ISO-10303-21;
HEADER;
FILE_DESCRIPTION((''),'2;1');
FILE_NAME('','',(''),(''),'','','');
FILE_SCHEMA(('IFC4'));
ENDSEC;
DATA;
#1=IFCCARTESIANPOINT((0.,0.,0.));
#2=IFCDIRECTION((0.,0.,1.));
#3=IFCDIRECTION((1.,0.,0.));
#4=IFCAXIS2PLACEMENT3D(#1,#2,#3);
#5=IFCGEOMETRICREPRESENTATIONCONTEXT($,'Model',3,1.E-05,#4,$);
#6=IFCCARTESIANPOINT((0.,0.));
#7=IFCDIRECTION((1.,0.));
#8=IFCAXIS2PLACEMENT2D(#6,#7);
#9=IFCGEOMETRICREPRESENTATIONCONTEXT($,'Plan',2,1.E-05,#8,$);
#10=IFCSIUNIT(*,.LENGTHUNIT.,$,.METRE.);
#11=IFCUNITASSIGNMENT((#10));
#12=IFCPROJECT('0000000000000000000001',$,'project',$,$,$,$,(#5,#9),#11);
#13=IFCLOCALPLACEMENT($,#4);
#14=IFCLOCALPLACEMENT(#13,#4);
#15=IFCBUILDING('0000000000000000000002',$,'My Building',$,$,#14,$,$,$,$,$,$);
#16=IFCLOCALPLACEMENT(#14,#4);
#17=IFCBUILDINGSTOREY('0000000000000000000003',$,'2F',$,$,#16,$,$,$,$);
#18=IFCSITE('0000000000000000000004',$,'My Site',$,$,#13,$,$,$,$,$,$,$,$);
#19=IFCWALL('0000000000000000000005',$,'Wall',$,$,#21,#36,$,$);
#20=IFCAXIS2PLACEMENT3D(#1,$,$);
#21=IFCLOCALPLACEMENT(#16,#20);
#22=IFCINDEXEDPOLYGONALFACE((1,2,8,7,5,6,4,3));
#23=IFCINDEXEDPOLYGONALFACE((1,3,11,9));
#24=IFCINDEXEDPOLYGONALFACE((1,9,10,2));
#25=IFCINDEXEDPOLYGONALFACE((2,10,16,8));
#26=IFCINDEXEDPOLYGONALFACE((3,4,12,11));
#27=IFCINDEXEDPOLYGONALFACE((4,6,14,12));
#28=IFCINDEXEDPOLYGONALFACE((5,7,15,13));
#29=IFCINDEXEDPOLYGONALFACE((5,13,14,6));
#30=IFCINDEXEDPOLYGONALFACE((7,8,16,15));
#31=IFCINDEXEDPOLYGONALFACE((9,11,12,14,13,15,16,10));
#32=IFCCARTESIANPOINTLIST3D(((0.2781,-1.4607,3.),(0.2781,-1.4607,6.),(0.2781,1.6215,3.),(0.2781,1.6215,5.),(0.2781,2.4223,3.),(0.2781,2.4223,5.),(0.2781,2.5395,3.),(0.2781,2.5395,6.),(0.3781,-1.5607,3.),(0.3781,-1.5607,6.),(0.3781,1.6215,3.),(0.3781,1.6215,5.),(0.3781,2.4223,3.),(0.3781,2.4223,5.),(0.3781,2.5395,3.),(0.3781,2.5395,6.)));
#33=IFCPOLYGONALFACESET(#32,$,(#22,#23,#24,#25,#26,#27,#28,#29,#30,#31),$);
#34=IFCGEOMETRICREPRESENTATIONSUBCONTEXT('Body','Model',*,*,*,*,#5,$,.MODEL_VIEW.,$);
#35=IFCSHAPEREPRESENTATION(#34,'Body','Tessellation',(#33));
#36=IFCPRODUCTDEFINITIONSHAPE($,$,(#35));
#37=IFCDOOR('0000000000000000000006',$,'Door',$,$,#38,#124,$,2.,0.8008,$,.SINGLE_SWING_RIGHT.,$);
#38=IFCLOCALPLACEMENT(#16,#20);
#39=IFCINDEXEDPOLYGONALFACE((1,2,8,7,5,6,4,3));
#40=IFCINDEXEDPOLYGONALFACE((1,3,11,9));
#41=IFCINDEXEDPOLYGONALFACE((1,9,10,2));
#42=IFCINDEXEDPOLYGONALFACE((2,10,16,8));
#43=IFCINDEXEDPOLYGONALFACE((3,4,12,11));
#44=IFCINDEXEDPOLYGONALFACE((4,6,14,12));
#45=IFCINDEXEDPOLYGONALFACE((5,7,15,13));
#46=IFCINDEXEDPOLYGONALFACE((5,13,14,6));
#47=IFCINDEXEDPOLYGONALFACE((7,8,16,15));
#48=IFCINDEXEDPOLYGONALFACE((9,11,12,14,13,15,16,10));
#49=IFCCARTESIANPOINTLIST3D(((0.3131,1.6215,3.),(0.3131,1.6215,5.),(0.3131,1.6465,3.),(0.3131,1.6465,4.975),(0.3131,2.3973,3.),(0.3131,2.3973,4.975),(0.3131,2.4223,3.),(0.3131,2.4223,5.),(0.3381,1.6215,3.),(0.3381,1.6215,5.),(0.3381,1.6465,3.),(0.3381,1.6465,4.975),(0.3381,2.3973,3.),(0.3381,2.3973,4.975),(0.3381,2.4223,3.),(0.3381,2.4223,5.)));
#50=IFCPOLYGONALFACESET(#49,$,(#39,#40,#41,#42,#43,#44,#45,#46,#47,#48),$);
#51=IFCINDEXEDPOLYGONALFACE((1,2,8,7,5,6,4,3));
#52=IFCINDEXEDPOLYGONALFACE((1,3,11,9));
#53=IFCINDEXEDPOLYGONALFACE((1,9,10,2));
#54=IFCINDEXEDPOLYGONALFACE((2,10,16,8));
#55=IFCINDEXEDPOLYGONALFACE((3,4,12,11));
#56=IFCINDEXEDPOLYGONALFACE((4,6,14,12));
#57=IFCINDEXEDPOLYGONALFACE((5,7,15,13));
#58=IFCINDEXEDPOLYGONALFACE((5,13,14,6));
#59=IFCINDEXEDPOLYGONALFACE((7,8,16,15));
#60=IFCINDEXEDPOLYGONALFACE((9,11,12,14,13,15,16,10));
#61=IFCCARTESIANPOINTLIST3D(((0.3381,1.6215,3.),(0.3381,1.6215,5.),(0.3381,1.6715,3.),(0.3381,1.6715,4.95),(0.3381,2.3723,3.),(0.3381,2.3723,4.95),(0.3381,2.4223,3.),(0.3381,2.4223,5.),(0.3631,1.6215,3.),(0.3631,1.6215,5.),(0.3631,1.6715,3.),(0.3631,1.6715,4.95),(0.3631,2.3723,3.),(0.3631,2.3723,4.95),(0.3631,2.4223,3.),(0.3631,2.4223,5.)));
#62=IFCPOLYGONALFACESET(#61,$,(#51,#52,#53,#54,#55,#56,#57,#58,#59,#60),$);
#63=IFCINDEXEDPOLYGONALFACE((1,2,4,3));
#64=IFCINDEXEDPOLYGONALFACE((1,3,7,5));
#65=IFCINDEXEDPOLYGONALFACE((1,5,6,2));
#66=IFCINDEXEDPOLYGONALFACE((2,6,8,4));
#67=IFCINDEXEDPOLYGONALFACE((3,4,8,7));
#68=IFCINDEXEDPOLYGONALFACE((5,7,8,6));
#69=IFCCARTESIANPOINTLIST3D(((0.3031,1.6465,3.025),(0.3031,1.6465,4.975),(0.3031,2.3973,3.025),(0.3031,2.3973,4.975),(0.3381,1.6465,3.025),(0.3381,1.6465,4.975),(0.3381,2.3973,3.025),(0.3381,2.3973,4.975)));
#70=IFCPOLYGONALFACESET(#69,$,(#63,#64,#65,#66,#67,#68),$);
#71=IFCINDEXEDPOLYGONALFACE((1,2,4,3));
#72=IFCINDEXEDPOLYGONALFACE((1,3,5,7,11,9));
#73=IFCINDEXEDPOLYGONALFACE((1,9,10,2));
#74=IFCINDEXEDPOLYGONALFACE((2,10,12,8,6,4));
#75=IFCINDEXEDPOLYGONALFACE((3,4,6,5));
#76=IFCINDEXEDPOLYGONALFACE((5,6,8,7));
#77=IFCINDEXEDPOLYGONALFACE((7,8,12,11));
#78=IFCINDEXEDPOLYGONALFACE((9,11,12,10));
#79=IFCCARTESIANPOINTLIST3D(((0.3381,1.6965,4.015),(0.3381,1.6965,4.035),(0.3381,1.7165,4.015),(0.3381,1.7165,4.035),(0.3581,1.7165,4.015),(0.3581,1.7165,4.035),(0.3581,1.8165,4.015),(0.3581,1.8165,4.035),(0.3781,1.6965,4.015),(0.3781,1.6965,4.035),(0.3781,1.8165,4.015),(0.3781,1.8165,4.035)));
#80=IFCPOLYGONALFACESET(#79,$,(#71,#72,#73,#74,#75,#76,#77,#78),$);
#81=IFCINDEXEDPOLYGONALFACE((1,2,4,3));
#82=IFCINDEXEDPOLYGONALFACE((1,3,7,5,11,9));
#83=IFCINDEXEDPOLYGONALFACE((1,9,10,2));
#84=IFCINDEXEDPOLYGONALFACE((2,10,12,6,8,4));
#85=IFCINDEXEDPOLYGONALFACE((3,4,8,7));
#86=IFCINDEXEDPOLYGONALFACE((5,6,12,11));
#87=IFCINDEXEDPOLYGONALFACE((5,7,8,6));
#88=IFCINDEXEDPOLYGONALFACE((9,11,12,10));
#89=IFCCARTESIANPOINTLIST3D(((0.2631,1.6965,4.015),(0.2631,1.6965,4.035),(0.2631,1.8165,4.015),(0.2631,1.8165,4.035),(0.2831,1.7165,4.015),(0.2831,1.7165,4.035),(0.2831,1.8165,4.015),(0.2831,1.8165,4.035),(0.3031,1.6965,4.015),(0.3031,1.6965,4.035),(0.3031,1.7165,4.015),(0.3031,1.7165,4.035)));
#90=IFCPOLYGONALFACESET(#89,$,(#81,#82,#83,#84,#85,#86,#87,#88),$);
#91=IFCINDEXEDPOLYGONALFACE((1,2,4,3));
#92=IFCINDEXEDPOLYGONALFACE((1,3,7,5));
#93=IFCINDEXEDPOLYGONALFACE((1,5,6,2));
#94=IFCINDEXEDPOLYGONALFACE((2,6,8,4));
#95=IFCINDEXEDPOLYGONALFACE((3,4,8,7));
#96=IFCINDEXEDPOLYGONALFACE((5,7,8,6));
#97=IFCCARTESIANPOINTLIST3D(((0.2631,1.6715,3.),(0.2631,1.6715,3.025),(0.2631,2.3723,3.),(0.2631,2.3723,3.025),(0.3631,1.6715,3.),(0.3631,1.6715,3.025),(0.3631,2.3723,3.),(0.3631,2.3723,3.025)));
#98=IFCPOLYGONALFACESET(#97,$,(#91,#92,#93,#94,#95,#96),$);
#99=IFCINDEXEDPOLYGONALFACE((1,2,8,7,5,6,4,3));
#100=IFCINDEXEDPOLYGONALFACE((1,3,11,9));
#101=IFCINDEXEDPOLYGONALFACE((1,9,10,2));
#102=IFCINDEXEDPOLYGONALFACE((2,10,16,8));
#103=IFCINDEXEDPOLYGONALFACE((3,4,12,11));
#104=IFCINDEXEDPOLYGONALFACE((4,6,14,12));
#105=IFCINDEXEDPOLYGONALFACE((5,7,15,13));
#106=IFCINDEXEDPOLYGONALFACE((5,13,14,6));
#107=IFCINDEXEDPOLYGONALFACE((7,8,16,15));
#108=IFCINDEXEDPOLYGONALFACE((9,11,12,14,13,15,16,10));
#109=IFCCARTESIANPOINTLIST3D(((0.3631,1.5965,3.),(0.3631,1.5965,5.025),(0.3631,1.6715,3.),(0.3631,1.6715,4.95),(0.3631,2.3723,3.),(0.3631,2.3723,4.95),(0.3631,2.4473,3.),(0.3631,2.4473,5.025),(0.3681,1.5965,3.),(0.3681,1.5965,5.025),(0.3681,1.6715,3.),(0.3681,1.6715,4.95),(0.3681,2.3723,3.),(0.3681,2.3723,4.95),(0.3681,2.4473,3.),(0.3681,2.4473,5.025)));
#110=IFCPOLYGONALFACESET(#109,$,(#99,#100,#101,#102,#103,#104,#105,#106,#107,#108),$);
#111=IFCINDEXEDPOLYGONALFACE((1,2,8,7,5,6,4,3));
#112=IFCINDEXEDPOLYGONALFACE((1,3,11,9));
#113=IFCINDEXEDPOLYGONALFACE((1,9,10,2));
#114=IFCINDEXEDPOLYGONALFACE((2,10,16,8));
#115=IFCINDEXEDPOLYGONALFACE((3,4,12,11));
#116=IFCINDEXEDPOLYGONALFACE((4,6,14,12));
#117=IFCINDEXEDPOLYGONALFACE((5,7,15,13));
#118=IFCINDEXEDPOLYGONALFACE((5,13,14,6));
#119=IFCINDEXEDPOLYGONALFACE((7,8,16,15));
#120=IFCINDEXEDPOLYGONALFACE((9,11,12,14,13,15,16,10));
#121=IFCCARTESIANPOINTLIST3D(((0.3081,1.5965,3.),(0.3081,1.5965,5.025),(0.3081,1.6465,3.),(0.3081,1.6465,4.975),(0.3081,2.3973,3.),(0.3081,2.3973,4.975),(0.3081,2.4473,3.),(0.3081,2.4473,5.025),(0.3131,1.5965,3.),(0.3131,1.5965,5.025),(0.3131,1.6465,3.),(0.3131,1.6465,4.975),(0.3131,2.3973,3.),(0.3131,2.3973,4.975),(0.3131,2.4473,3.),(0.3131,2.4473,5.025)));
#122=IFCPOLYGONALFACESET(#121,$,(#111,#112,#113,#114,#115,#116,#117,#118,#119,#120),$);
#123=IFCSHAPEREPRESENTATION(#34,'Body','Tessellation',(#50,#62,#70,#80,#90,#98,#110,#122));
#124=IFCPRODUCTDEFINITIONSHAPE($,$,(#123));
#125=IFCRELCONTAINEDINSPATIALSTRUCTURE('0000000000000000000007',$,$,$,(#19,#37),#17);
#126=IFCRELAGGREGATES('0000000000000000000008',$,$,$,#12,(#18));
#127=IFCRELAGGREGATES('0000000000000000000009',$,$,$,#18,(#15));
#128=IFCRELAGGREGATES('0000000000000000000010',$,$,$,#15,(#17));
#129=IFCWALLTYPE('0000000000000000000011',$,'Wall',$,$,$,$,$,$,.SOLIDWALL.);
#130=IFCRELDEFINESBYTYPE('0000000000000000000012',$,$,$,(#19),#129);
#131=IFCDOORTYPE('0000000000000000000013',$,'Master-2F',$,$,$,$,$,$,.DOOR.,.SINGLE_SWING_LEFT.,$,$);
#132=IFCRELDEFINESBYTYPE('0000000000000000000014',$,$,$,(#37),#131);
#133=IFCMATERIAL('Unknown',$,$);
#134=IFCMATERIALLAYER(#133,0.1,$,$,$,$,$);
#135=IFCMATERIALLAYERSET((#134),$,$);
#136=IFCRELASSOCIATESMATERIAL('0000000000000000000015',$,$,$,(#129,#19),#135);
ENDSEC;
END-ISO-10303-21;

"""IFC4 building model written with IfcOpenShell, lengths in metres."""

from ifc_helpers import new_model, entity, si_unit, frame, origin_with_axes, origin_2d_with_axis, place, context, subcontext, project, spatial, line, indexed_curve, outline, extrude, shape, source, transform, mapped, material, layer, layer_set, layer_usage, type_object, type_shapes, element, fill, save


model = new_model("IFC4")

# Units and contexts
model_context = context("Model", 3, precision=1e-05, world=origin_with_axes())
plan_context = context("Plan", 2, precision=1e-05, world=origin_2d_with_axis())
body_context_1 = subcontext(model_context, "Body", "Model", "MODEL_VIEW")
body_context_2 = subcontext(plan_context, "Body", "Plan", "PLAN_VIEW")
ifc_project = project(units=[si_unit("LENGTHUNIT", "METRE")], contexts=[model_context, plan_context])

# Site, building, storey
site_placement = place(None, origin_with_axes())
site = spatial("IfcSite", under=ifc_project, at=site_placement, Name="My Site")
building_placement = place(site_placement, origin_with_axes())
building = spatial("IfcBuilding", under=site, at=building_placement, Name="My Building")
storey_placement = place(building_placement, origin_with_axes())
storey = spatial("IfcBuildingStorey", under=building, at=storey_placement, Name="2F")

# Shared definitions
ifc_material = material(Name="Unknown")

# Shared definitions
ifc_layer = layer(ifc_material, 0.1)
ifc_layer_set = layer_set([ifc_layer])
wall_type = type_object("IfcWallType", Name="Wall", PredefinedType="SOLIDWALL", material=ifc_layer_set)

# Wall, opening, door
ifc_layer_usage_1 = layer_usage(ifc_layer_set, "AXIS2", "POSITIVE", 0.0)
wall_1_placement = place(storey_placement, frame((0.3781, -1.5607, 3.0), z_axis=(0.0, 0.0, 1.0), x_axis=(0.0, 1.0, 0.0)))
wall_1 = element("IfcWall", 1, at=wall_1_placement, inside=storey, type_object=wall_type, material=ifc_layer_usage_1, Name="Wall", context=body_context_1, shape_type="SweptSolid", body=[
    extrude(outline(indexed_curve([(0.0, 0.0), (0.1, 0.1), (4.1002, 0.1), (4.1002, 0.0)], segments=[line(1, 2, 3, 4, 1)])), origin_with_axes(), (0.0, 0.0, 1.0), 3.0),
])
shared_shape_1 = source(origin_with_axes(), body_context_1, "Body", "SweptSolid", [
    extrude(outline(indexed_curve([(0.0, 0.0), (0.8008, 0.0), (0.8008, 2.0), (0.0, 2.0)], segments=[line(1, 2, 3, 4, 1)])), frame((0.0, -0.6, 0.0), z_axis=(0.0, -1.0, 0.0), x_axis=(1.0, 0.0, 0.0)), (0.0, 0.0, -1.0), 1.2),
])
opening_1_placement = place(wall_1_placement, frame((3.1821, 0.015, 0.0), z_axis=(0.0, 0.0, 1.0), x_axis=(1.0, 0.0, 0.0)))
opening_1 = element("IfcOpeningElement", 2, at=opening_1_placement, cuts=wall_1, PredefinedType="OPENING", context=body_context_1, shape_type="MappedRepresentation", body=[
    mapped(shared_shape_1, transform((0.0, 0.0, 0.0), x_axis=(1.0, 0.0, 0.0), y_axis=(0.0, 1.0, 0.0), z_axis=(0.0, 0.0, 1.0), scale=1.0)),
])
door_type_1 = type_object("IfcDoorType", Name="Master-2F", OperationType="SINGLE_SWING_LEFT", PredefinedType="DOOR")
shared_shape_2 = source(origin_with_axes(), body_context_1, "Body", "SweptSolid", [
    extrude(outline(indexed_curve([(0.0, 0.0), (0.0, 2.0), (0.8008, 2.0), (0.8008, 0.0), (0.7758, 0.0), (0.7758, 1.975), (0.025, 1.975), (0.025, 0.0)], segments=[line(1, 2, 3, 4, 5, 6, 7, 8, 1)])), frame((0.0, 0.025, 0.0), z_axis=(0.0, -1.0, 0.0), x_axis=(1.0, 0.0, 0.0)), (0.0, 0.0, -1.0), 0.025),
    extrude(outline(indexed_curve([(0.0, 0.0), (0.0, 2.0), (0.8008, 2.0), (0.8008, 0.0), (0.7508, 0.0), (0.7508, 1.95), (0.05, 1.95), (0.05, 0.0)], segments=[line(1, 2, 3, 4, 5, 6, 7, 8, 1)])), frame((0.0, 0.0, 0.0), z_axis=(0.0, -1.0, 0.0), x_axis=(1.0, 0.0, 0.0)), (0.0, 0.0, -1.0), 0.025),
    extrude(outline(indexed_curve([(0.0, 0.0), (0.7508, 0.0), (0.7508, 0.035), (0.0, 0.035)], segments=[line(1, 2, 3, 4, 1)])), frame((0.025, 0.025, 0.025), z_axis=(0.0, 0.0, 1.0), x_axis=(1.0, 0.0, 0.0)), (0.0, 0.0, 1.0), 1.95),
    extrude(outline(indexed_curve([(0.0, 0.0), (0.0, -0.04), (0.12, -0.04), (0.12, -0.02), (0.02, -0.02), (0.02, 0.0)], segments=[line(1, 2, 3, 4, 5, 6, 1)])), frame((0.075, 0.025, 1.015), z_axis=(0.0, 0.0, 1.0), x_axis=(1.0, 0.0, 0.0)), (0.0, 0.0, 1.0), 0.02),
    extrude(outline(indexed_curve([(0.0, 0.0), (0.0, 0.04), (0.12, 0.04), (0.12, 0.02), (0.02, 0.02), (0.02, 0.0)], segments=[line(1, 2, 3, 4, 5, 6, 1)])), frame((0.075, 0.06, 1.015), z_axis=(0.0, 0.0, 1.0), x_axis=(1.0, 0.0, 0.0)), (0.0, 0.0, 1.0), 0.02),
    extrude(outline(indexed_curve([(0.0, 0.0), (0.7008, 0.0), (0.7008, 0.1), (0.0, 0.1)], segments=[line(1, 2, 3, 4, 1)])), frame((0.05, 0.0, 0.0), z_axis=(0.0, 0.0, 1.0), x_axis=(1.0, 0.0, 0.0)), (0.0, 0.0, 1.0), 0.025),
    extrude(outline(indexed_curve([(0.0, 0.0), (0.0, 2.025), (0.8508, 2.025), (0.8508, 0.0), (0.7758, 0.0), (0.7758, 1.95), (0.075, 1.95), (0.075, 0.0)], segments=[line(1, 2, 3, 4, 5, 6, 7, 8, 1)])), frame((-0.025, -0.005, 0.0), z_axis=(0.0, -1.0, 0.0), x_axis=(1.0, 0.0, 0.0)), (0.0, 0.0, -1.0), 0.005),
    extrude(outline(indexed_curve([(0.0, 0.0), (0.0, 2.025), (0.8508, 2.025), (0.8508, 0.0), (0.8008, 0.0), (0.8008, 1.975), (0.05, 1.975), (0.05, 0.0)], segments=[line(1, 2, 3, 4, 5, 6, 7, 8, 1)])), frame((-0.025, 0.05, 0.0), z_axis=(0.0, -1.0, 0.0), x_axis=(1.0, 0.0, 0.0)), (0.0, 0.0, -1.0), 0.005),
])
shared_shape_3 = source(origin_with_axes(), body_context_2, "Body", "Curve2D", [
    entity("IfcIndexedPolyCurve", entity("IfcCartesianPointList2D", [[0.0, 0.0], [0.0, 0.05], [0.025, 0.05], [0.025, 0.025], [0.05, 0.025], [0.05, 0.0]]), [entity("IfcLineIndex", [1, 2, 3, 4, 5, 6, 1])]),
    entity("IfcIndexedPolyCurve", entity("IfcCartesianPointList2D", [[0.8008, 0.0], [0.8008, 0.05], [0.7758, 0.05], [0.7758, 0.025], [0.7508, 0.025], [0.7508, 0.0]]), [entity("IfcLineIndex", [1, 2, 3, 4, 5, 6, 1])]),
    entity("IfcTrimmedCurve", entity("IfcEllipse", entity("IfcAxis2Placement2D", entity("IfcCartesianPoint", [0.7408, 0.05]), entity("IfcDirection", [1.0, 0.0])), 0.7158, 0.7508), [entity("IfcCartesianPoint", [0.7408, 0.8008])], [entity("IfcCartesianPoint", [0.025, 0.05])], True, "CARTESIAN"),
    entity("IfcIndexedPolyCurve", entity("IfcCartesianPointList2D", [[0.7758, 0.05], [0.7408, 0.05], [0.7408, 0.8008], [0.7758, 0.8008]]), [entity("IfcLineIndex", [1, 2, 3, 4, 1])]),
])
type_shapes(door_type_1, [shared_shape_2, shared_shape_3])
door_1_placement = place(opening_1_placement, frame((0.0, 0.0, 0.0), z_axis=(0.0, 0.0, 1.0), x_axis=(1.0, 0.0, 0.0)))
door_1 = element("IfcDoor", 3, at=door_1_placement, inside=storey, type_object=door_type_1, Name="Door", OperationType="SINGLE_SWING_RIGHT", OverallHeight=2.0, OverallWidth=0.8008, shapes=[
    shape(body_context_1, "Body", "MappedRepresentation", [mapped(shared_shape_2, transform((0.0, 0.0, 0.0), x_axis=(1.0, 0.0, 0.0), y_axis=(0.0, 1.0, 0.0), z_axis=(0.0, 0.0, 1.0), scale=1.0))]),
    shape(body_context_2, "Body", "MappedRepresentation", [mapped(shared_shape_3, transform((0.0, 0.0, 0.0), x_axis=(1.0, 0.0, 0.0), y_axis=(0.0, 1.0, 0.0), z_axis=(0.0, 0.0, 1.0), scale=1.0))]),
])
fill(opening_1, door_1)

save(model, "model.ifc")
